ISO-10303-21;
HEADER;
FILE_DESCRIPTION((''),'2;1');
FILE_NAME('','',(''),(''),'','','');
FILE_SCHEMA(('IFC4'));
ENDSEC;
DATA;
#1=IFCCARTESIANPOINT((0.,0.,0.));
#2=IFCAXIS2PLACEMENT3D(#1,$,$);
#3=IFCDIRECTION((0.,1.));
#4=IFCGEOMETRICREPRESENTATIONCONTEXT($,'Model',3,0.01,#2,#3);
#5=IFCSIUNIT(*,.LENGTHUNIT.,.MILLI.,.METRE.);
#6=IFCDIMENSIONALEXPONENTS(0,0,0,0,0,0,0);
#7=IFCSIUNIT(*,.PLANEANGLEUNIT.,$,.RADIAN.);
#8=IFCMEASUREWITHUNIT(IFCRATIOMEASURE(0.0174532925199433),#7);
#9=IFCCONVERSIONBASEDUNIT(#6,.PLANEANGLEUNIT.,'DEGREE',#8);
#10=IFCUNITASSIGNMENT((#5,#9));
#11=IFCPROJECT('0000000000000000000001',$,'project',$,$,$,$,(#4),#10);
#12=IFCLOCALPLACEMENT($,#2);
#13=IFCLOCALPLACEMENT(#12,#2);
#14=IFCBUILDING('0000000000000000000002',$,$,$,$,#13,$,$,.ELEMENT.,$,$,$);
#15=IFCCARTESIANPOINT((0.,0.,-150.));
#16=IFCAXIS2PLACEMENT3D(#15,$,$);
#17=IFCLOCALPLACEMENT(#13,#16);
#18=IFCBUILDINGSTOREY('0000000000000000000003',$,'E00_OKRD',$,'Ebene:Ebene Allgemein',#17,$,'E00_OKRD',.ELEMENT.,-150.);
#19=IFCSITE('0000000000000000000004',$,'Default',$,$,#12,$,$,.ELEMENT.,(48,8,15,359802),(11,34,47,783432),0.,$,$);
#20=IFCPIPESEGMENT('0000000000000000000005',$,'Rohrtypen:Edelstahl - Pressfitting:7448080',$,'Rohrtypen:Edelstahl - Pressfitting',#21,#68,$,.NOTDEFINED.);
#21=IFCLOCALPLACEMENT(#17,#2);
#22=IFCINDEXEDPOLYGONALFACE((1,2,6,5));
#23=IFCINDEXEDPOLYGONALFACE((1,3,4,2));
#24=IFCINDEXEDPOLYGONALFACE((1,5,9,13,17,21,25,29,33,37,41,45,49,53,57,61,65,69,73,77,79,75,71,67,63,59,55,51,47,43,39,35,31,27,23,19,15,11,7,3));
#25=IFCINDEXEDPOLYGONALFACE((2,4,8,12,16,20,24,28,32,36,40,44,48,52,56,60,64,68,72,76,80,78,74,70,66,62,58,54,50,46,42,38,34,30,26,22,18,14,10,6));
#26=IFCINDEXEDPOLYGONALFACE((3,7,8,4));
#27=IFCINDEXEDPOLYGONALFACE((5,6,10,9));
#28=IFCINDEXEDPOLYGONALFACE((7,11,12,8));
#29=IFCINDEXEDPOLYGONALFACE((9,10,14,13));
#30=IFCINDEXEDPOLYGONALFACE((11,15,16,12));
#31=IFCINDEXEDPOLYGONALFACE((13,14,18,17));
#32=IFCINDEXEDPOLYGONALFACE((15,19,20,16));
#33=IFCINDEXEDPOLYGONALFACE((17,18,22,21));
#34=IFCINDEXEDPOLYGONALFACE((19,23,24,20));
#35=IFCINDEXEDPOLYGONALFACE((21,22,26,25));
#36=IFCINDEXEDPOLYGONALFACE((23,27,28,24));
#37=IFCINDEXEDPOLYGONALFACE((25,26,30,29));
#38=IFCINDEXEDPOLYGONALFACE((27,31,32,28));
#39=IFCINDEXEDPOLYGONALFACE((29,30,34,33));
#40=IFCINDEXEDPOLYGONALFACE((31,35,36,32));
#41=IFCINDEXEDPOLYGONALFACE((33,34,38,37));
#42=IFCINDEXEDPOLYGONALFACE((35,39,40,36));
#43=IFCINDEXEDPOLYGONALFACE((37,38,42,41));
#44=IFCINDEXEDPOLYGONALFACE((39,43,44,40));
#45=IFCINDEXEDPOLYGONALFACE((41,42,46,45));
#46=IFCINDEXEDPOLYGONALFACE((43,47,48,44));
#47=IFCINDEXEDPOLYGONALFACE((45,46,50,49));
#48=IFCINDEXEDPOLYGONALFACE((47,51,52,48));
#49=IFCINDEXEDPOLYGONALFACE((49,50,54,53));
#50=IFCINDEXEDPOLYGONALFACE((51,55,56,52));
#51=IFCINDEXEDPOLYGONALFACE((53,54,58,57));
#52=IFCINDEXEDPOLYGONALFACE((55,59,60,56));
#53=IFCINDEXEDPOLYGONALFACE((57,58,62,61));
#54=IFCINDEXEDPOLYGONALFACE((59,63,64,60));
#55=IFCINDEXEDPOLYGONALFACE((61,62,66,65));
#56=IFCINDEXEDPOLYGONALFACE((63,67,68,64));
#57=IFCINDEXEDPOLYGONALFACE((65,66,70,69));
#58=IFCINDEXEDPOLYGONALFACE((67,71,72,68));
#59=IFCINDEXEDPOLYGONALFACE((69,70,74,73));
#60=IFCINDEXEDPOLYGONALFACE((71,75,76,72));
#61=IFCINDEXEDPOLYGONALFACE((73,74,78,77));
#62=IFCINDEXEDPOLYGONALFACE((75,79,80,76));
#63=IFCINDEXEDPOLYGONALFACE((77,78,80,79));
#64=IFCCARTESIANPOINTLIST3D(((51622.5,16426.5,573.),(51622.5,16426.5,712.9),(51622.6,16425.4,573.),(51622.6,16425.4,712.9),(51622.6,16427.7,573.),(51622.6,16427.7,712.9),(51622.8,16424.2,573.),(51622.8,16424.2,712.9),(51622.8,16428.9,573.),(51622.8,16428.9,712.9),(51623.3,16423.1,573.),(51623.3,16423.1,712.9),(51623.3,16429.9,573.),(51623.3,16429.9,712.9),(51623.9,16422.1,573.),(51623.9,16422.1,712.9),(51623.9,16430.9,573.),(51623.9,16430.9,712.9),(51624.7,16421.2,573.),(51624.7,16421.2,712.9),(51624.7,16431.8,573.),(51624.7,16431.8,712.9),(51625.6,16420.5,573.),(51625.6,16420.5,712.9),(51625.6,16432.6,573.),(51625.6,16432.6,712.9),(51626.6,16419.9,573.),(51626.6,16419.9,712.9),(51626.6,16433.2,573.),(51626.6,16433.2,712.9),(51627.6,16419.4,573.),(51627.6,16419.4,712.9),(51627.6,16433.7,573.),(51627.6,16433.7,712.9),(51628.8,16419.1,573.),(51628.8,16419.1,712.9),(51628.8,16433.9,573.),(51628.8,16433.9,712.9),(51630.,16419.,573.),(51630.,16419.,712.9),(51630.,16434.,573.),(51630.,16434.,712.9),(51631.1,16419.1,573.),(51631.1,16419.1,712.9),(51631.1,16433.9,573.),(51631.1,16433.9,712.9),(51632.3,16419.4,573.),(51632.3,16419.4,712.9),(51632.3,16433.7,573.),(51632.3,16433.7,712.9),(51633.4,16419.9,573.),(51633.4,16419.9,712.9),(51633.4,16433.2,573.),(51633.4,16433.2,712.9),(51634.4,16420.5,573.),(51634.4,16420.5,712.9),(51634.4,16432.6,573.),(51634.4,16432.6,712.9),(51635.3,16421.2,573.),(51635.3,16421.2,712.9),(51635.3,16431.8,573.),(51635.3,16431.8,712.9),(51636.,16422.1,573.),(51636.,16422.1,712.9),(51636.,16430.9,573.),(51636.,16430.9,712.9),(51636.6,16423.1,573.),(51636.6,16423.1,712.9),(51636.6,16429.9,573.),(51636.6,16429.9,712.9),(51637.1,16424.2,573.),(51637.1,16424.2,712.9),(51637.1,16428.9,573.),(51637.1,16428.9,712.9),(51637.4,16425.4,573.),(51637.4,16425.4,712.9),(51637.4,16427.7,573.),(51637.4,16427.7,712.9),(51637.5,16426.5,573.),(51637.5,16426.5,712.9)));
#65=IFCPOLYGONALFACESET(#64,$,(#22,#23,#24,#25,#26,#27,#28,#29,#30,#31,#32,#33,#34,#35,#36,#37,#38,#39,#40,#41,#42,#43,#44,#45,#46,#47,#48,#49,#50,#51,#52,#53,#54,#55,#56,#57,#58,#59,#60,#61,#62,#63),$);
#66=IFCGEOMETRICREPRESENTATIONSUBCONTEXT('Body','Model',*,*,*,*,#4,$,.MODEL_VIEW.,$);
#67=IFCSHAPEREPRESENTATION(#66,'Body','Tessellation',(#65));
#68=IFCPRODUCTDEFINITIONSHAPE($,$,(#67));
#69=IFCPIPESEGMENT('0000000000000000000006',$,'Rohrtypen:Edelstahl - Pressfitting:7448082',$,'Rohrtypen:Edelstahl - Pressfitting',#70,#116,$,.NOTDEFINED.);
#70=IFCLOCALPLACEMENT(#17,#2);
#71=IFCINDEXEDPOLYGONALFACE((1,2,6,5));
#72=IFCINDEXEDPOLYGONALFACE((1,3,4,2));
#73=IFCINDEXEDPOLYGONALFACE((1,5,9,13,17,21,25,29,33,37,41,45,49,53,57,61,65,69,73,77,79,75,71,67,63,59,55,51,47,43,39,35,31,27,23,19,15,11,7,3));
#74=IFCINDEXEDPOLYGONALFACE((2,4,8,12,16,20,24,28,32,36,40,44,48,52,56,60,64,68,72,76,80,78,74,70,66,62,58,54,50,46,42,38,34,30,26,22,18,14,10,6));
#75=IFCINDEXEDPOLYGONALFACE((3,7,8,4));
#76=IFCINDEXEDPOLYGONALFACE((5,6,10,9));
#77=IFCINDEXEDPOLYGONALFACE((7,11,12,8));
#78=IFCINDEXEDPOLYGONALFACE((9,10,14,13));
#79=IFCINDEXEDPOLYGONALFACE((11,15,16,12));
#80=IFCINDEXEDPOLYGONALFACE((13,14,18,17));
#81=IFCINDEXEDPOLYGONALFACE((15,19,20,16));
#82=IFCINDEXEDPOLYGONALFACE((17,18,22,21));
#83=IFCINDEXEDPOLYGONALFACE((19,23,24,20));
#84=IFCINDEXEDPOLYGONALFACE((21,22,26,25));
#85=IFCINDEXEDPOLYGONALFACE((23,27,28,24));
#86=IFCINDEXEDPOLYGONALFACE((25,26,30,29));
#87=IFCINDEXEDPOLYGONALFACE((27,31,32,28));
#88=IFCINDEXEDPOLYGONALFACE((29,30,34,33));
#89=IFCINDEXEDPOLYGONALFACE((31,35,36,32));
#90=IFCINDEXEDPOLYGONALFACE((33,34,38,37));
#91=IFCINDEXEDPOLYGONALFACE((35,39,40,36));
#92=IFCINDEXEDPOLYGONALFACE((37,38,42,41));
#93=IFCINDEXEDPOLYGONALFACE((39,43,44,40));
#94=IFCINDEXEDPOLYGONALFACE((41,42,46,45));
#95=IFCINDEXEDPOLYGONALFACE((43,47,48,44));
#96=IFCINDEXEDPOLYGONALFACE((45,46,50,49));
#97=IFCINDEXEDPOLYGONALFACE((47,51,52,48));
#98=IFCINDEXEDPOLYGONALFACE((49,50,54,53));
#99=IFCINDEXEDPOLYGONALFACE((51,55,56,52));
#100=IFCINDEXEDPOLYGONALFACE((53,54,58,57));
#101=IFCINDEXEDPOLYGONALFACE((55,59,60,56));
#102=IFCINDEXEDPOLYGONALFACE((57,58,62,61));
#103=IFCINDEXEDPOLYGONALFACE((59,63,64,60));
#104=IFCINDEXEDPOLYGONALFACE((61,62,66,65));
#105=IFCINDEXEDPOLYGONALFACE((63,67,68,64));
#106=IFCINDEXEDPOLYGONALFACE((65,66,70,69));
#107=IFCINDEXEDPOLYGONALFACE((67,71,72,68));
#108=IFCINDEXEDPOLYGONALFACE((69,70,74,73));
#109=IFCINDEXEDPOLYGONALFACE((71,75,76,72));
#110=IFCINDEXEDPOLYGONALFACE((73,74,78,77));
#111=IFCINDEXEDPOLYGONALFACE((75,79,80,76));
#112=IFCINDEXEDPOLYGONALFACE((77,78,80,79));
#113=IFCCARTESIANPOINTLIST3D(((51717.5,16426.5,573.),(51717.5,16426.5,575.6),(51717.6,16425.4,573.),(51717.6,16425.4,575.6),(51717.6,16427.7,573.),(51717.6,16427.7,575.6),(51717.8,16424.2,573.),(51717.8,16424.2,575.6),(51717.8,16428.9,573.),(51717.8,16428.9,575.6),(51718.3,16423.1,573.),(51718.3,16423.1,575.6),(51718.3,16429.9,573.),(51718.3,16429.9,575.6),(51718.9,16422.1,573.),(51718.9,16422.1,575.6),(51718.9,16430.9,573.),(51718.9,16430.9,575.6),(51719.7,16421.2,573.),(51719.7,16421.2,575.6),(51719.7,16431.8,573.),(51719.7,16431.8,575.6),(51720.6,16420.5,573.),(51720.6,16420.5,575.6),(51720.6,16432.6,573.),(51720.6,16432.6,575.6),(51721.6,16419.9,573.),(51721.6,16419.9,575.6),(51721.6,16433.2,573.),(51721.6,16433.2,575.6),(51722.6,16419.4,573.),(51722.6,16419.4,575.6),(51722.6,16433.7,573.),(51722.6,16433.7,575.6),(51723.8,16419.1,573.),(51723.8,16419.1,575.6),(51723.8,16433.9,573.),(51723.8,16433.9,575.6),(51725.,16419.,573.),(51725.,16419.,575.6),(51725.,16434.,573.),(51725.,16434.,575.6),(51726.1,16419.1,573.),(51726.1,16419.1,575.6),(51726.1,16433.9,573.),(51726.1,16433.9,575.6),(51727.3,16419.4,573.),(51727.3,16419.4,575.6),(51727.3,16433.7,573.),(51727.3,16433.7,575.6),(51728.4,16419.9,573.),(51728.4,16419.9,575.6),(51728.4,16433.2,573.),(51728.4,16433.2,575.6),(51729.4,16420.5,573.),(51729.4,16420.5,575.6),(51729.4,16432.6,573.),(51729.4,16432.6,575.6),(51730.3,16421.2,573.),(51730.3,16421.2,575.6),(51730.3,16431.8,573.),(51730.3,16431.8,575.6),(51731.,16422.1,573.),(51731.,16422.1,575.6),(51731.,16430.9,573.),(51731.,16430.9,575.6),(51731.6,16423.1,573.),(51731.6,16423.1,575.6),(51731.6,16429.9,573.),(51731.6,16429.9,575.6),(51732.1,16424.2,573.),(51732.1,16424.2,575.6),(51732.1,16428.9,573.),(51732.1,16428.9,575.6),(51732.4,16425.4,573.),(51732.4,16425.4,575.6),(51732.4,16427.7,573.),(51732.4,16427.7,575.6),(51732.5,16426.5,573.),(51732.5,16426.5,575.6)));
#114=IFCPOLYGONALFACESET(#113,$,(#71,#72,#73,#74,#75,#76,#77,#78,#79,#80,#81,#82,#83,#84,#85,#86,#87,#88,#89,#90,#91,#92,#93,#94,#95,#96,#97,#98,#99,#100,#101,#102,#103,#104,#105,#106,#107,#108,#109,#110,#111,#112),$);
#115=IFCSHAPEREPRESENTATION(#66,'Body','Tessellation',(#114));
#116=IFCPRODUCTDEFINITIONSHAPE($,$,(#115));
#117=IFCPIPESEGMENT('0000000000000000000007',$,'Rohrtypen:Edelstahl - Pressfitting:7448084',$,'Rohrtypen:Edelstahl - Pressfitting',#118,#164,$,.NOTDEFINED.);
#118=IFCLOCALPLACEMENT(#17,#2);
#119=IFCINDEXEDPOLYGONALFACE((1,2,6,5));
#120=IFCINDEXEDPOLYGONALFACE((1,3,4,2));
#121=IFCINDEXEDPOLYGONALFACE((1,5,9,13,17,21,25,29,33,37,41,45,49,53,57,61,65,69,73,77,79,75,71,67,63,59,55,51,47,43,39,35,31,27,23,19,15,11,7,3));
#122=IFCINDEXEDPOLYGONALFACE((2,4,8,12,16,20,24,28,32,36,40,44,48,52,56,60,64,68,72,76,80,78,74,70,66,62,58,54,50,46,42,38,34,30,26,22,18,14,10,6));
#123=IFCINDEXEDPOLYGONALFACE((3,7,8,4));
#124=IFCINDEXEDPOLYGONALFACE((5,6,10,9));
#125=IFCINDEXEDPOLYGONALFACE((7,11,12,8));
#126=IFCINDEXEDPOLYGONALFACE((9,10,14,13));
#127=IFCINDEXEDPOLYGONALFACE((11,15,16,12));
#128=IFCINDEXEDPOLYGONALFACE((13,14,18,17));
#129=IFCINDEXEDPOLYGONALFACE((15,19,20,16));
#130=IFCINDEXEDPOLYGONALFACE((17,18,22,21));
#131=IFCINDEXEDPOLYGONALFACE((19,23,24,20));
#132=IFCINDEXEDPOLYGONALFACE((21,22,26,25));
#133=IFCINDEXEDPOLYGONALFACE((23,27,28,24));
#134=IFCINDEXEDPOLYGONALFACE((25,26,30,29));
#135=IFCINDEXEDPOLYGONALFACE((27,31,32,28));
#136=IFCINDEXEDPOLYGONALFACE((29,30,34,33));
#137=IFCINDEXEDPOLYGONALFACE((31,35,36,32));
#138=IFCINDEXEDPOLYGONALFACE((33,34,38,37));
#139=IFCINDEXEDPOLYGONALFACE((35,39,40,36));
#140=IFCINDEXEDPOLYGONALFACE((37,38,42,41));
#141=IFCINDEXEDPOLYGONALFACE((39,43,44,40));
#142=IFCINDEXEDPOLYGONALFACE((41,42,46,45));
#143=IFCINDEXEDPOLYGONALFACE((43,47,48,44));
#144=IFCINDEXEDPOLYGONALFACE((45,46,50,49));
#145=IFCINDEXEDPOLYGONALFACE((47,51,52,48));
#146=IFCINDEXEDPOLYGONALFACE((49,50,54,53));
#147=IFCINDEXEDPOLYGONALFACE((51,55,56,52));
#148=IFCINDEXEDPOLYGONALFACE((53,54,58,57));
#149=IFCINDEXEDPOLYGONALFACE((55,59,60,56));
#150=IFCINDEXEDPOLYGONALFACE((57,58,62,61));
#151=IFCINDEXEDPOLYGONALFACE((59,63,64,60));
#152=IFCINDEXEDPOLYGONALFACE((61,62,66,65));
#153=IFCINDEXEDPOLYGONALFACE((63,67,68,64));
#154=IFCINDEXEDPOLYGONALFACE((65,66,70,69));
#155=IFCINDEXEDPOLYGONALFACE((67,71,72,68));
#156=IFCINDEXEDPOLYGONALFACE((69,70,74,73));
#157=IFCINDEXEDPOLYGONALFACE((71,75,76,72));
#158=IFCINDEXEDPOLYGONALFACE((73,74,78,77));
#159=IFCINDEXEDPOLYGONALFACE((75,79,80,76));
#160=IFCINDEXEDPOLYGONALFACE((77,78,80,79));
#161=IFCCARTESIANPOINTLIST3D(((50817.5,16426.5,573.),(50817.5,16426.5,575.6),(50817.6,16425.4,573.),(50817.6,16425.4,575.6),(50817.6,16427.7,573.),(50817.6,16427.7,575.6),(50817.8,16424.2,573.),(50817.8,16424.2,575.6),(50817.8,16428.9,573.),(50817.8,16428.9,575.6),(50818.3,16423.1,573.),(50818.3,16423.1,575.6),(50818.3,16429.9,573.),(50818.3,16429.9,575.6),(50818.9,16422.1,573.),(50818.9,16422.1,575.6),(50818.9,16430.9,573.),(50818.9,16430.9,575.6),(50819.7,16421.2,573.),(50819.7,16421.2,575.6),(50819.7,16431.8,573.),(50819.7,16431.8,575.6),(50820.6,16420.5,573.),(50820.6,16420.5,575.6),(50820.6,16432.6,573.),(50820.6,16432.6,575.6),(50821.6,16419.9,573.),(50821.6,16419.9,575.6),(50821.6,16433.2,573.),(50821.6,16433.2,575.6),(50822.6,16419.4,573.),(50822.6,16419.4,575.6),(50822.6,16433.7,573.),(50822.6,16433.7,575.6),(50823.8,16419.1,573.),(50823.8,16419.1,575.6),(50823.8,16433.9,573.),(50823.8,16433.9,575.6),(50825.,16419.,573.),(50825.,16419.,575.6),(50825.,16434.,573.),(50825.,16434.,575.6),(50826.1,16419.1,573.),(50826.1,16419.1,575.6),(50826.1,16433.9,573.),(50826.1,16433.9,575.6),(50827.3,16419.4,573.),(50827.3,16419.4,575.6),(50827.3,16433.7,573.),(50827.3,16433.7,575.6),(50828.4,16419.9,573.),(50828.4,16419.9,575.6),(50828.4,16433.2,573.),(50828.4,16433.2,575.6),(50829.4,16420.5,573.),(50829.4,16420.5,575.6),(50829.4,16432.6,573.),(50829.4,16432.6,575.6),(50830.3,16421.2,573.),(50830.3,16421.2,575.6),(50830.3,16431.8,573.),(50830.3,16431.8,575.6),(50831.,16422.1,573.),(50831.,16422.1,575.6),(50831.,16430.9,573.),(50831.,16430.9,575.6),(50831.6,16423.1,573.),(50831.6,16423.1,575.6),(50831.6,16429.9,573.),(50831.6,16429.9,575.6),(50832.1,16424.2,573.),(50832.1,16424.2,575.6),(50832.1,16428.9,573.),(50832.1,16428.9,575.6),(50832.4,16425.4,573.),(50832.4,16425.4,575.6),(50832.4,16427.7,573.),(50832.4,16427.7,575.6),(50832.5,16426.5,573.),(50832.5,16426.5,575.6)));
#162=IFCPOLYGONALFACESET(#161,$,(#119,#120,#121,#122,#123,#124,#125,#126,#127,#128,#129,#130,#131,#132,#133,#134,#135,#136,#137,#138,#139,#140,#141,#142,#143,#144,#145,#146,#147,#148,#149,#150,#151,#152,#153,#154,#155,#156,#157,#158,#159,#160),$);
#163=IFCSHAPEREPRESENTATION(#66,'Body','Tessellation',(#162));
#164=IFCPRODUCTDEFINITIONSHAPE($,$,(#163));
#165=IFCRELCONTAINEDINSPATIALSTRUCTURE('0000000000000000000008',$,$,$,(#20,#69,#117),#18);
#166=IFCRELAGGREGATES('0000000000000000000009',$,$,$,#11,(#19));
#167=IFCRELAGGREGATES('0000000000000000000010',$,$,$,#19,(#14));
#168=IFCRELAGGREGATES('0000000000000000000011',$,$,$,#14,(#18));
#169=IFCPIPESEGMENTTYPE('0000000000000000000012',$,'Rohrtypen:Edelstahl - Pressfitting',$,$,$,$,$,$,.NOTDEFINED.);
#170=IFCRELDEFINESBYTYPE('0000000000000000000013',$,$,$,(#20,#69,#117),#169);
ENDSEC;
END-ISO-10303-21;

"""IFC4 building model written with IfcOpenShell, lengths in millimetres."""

from ifc_helpers import new_model, entity, si_unit, converted_unit, direction, frame, origin, place, context, subcontext, project, spatial, indexed_curve, outline, extrude, type_object, element, save


model = new_model("IFC4")

# Units and contexts
model_context = context("Model", 3, precision=0.01, world=origin(), true_north=direction((0.0, 1.0)))
body_context = subcontext(model_context, "Body", "Model", "MODEL_VIEW")
ifc_project = project(units=[si_unit("LENGTHUNIT", "METRE", prefix="MILLI"), converted_unit("PLANEANGLEUNIT", "DEGREE", entity("IfcRatioMeasure", 0.0174532925199433), si_unit("PLANEANGLEUNIT", "RADIAN"), dimensions=[0, 0, 0, 0, 0, 0, 0])], contexts=[model_context])

# Site, building, storey
site_placement = place(None, origin())
site = spatial("IfcSite", under=ifc_project, at=site_placement, Name="Default", CompositionType="ELEMENT", RefLatitude=(48, 8, 15, 359802), RefLongitude=(11, 34, 47, 783432), RefElevation=0.0)
building_placement = place(site_placement, origin())
building = spatial("IfcBuilding", under=site, at=building_placement, CompositionType="ELEMENT")
storey_placement = place(building_placement, frame((0.0, 0.0, -150.0)))
storey = spatial("IfcBuildingStorey", under=building, at=storey_placement, Name="E00_OKRD", ObjectType="Ebene:Ebene Allgemein", LongName="E00_OKRD", CompositionType="ELEMENT", Elevation=-150.0)

# Pipe segments
pipe_segment_type_1 = type_object("IfcPipeSegmentType", Name="Rohrtypen:Edelstahl - Pressfitting", PredefinedType="NOTDEFINED")
pipe_segment_1_placement = place(storey_placement, origin())
element("IfcPipeSegment", 1, at=pipe_segment_1_placement, inside=storey, type_object=pipe_segment_type_1, Name="Rohrtypen:Edelstahl - Pressfitting:7448080", ObjectType="Rohrtypen:Edelstahl - Pressfitting", PredefinedType="NOTDEFINED", context=body_context, shape_type="SweptSolid", body=[
    extrude(outline(indexed_curve([(7.5, 0.0), (7.4, 1.2), (7.1, 2.3), (6.7, 3.4), (6.1, 4.4), (5.3, 5.3), (4.4, 6.1), (3.4, 6.7), (2.3, 7.1), (1.2, 7.4), (0.0, 7.5), (-1.2, 7.4), (-2.3, 7.1), (-3.4, 6.7), (-4.4, 6.1), (-5.3, 5.3), (-6.1, 4.4), (-6.7, 3.4), (-7.1, 2.3), (-7.4, 1.2), (-7.5, 0.0), (-7.4, -1.2), (-7.1, -2.3), (-6.7, -3.4), (-6.1, -4.4), (-5.3, -5.3), (-4.4, -6.1), (-3.4, -6.7), (-2.3, -7.1), (-1.2, -7.4), (0.0, -7.5), (1.2, -7.4), (2.3, -7.1), (3.4, -6.7), (4.4, -6.1), (5.3, -5.3), (6.1, -4.4), (6.7, -3.4), (7.1, -2.3), (7.4, -1.2), (7.5, 0.0)], self_intersect=False)), frame((51630.0, 16426.5, 573.0), z_axis=(0.0, 0.0, 1.0), x_axis=(-1.0, 0.0, 0.0)), (0.0, 0.0, 1.0), 139.9),
])
pipe_segment_2_placement = place(storey_placement, origin())
element("IfcPipeSegment", 2, at=pipe_segment_2_placement, inside=storey, type_object=pipe_segment_type_1, Name="Rohrtypen:Edelstahl - Pressfitting:7448082", ObjectType="Rohrtypen:Edelstahl - Pressfitting", PredefinedType="NOTDEFINED", context=body_context, shape_type="SweptSolid", body=[
    extrude(outline(indexed_curve([(7.5, 0.0), (7.4, 1.2), (7.1, 2.3), (6.7, 3.4), (6.1, 4.4), (5.3, 5.3), (4.4, 6.1), (3.4, 6.7), (2.3, 7.1), (1.2, 7.4), (0.0, 7.5), (-1.2, 7.4), (-2.3, 7.1), (-3.4, 6.7), (-4.4, 6.1), (-5.3, 5.3), (-6.1, 4.4), (-6.7, 3.4), (-7.1, 2.3), (-7.4, 1.2), (-7.5, 0.0), (-7.4, -1.2), (-7.1, -2.3), (-6.7, -3.4), (-6.1, -4.4), (-5.3, -5.3), (-4.4, -6.1), (-3.4, -6.7), (-2.3, -7.1), (-1.2, -7.4), (0.0, -7.5), (1.2, -7.4), (2.3, -7.1), (3.4, -6.7), (4.4, -6.1), (5.3, -5.3), (6.1, -4.4), (6.7, -3.4), (7.1, -2.3), (7.4, -1.2), (7.5, 0.0)], self_intersect=False)), frame((51725.0, 16426.5, 573.0), z_axis=(0.0, 0.0, 1.0), x_axis=(-1.0, 0.0, 0.0)), (0.0, 0.0, 1.0), 2.6),
])
pipe_segment_3_placement = place(storey_placement, origin())
element("IfcPipeSegment", 3, at=pipe_segment_3_placement, inside=storey, type_object=pipe_segment_type_1, Name="Rohrtypen:Edelstahl - Pressfitting:7448084", ObjectType="Rohrtypen:Edelstahl - Pressfitting", PredefinedType="NOTDEFINED", context=body_context, shape_type="SweptSolid", body=[
    extrude(outline(indexed_curve([(7.5, 0.0), (7.4, 1.2), (7.1, 2.3), (6.7, 3.4), (6.1, 4.4), (5.3, 5.3), (4.4, 6.1), (3.4, 6.7), (2.3, 7.1), (1.2, 7.4), (0.0, 7.5), (-1.2, 7.4), (-2.3, 7.1), (-3.4, 6.7), (-4.4, 6.1), (-5.3, 5.3), (-6.1, 4.4), (-6.7, 3.4), (-7.1, 2.3), (-7.4, 1.2), (-7.5, 0.0), (-7.4, -1.2), (-7.1, -2.3), (-6.7, -3.4), (-6.1, -4.4), (-5.3, -5.3), (-4.4, -6.1), (-3.4, -6.7), (-2.3, -7.1), (-1.2, -7.4), (0.0, -7.5), (1.2, -7.4), (2.3, -7.1), (3.4, -6.7), (4.4, -6.1), (5.3, -5.3), (6.1, -4.4), (6.7, -3.4), (7.1, -2.3), (7.4, -1.2), (7.5, 0.0)], self_intersect=False)), frame((50825.0, 16426.5, 573.0), z_axis=(0.0, 0.0, 1.0), x_axis=(-1.0, 0.0, 0.0)), (0.0, 0.0, 1.0), 2.6),
])

save(model, "model.ifc")
